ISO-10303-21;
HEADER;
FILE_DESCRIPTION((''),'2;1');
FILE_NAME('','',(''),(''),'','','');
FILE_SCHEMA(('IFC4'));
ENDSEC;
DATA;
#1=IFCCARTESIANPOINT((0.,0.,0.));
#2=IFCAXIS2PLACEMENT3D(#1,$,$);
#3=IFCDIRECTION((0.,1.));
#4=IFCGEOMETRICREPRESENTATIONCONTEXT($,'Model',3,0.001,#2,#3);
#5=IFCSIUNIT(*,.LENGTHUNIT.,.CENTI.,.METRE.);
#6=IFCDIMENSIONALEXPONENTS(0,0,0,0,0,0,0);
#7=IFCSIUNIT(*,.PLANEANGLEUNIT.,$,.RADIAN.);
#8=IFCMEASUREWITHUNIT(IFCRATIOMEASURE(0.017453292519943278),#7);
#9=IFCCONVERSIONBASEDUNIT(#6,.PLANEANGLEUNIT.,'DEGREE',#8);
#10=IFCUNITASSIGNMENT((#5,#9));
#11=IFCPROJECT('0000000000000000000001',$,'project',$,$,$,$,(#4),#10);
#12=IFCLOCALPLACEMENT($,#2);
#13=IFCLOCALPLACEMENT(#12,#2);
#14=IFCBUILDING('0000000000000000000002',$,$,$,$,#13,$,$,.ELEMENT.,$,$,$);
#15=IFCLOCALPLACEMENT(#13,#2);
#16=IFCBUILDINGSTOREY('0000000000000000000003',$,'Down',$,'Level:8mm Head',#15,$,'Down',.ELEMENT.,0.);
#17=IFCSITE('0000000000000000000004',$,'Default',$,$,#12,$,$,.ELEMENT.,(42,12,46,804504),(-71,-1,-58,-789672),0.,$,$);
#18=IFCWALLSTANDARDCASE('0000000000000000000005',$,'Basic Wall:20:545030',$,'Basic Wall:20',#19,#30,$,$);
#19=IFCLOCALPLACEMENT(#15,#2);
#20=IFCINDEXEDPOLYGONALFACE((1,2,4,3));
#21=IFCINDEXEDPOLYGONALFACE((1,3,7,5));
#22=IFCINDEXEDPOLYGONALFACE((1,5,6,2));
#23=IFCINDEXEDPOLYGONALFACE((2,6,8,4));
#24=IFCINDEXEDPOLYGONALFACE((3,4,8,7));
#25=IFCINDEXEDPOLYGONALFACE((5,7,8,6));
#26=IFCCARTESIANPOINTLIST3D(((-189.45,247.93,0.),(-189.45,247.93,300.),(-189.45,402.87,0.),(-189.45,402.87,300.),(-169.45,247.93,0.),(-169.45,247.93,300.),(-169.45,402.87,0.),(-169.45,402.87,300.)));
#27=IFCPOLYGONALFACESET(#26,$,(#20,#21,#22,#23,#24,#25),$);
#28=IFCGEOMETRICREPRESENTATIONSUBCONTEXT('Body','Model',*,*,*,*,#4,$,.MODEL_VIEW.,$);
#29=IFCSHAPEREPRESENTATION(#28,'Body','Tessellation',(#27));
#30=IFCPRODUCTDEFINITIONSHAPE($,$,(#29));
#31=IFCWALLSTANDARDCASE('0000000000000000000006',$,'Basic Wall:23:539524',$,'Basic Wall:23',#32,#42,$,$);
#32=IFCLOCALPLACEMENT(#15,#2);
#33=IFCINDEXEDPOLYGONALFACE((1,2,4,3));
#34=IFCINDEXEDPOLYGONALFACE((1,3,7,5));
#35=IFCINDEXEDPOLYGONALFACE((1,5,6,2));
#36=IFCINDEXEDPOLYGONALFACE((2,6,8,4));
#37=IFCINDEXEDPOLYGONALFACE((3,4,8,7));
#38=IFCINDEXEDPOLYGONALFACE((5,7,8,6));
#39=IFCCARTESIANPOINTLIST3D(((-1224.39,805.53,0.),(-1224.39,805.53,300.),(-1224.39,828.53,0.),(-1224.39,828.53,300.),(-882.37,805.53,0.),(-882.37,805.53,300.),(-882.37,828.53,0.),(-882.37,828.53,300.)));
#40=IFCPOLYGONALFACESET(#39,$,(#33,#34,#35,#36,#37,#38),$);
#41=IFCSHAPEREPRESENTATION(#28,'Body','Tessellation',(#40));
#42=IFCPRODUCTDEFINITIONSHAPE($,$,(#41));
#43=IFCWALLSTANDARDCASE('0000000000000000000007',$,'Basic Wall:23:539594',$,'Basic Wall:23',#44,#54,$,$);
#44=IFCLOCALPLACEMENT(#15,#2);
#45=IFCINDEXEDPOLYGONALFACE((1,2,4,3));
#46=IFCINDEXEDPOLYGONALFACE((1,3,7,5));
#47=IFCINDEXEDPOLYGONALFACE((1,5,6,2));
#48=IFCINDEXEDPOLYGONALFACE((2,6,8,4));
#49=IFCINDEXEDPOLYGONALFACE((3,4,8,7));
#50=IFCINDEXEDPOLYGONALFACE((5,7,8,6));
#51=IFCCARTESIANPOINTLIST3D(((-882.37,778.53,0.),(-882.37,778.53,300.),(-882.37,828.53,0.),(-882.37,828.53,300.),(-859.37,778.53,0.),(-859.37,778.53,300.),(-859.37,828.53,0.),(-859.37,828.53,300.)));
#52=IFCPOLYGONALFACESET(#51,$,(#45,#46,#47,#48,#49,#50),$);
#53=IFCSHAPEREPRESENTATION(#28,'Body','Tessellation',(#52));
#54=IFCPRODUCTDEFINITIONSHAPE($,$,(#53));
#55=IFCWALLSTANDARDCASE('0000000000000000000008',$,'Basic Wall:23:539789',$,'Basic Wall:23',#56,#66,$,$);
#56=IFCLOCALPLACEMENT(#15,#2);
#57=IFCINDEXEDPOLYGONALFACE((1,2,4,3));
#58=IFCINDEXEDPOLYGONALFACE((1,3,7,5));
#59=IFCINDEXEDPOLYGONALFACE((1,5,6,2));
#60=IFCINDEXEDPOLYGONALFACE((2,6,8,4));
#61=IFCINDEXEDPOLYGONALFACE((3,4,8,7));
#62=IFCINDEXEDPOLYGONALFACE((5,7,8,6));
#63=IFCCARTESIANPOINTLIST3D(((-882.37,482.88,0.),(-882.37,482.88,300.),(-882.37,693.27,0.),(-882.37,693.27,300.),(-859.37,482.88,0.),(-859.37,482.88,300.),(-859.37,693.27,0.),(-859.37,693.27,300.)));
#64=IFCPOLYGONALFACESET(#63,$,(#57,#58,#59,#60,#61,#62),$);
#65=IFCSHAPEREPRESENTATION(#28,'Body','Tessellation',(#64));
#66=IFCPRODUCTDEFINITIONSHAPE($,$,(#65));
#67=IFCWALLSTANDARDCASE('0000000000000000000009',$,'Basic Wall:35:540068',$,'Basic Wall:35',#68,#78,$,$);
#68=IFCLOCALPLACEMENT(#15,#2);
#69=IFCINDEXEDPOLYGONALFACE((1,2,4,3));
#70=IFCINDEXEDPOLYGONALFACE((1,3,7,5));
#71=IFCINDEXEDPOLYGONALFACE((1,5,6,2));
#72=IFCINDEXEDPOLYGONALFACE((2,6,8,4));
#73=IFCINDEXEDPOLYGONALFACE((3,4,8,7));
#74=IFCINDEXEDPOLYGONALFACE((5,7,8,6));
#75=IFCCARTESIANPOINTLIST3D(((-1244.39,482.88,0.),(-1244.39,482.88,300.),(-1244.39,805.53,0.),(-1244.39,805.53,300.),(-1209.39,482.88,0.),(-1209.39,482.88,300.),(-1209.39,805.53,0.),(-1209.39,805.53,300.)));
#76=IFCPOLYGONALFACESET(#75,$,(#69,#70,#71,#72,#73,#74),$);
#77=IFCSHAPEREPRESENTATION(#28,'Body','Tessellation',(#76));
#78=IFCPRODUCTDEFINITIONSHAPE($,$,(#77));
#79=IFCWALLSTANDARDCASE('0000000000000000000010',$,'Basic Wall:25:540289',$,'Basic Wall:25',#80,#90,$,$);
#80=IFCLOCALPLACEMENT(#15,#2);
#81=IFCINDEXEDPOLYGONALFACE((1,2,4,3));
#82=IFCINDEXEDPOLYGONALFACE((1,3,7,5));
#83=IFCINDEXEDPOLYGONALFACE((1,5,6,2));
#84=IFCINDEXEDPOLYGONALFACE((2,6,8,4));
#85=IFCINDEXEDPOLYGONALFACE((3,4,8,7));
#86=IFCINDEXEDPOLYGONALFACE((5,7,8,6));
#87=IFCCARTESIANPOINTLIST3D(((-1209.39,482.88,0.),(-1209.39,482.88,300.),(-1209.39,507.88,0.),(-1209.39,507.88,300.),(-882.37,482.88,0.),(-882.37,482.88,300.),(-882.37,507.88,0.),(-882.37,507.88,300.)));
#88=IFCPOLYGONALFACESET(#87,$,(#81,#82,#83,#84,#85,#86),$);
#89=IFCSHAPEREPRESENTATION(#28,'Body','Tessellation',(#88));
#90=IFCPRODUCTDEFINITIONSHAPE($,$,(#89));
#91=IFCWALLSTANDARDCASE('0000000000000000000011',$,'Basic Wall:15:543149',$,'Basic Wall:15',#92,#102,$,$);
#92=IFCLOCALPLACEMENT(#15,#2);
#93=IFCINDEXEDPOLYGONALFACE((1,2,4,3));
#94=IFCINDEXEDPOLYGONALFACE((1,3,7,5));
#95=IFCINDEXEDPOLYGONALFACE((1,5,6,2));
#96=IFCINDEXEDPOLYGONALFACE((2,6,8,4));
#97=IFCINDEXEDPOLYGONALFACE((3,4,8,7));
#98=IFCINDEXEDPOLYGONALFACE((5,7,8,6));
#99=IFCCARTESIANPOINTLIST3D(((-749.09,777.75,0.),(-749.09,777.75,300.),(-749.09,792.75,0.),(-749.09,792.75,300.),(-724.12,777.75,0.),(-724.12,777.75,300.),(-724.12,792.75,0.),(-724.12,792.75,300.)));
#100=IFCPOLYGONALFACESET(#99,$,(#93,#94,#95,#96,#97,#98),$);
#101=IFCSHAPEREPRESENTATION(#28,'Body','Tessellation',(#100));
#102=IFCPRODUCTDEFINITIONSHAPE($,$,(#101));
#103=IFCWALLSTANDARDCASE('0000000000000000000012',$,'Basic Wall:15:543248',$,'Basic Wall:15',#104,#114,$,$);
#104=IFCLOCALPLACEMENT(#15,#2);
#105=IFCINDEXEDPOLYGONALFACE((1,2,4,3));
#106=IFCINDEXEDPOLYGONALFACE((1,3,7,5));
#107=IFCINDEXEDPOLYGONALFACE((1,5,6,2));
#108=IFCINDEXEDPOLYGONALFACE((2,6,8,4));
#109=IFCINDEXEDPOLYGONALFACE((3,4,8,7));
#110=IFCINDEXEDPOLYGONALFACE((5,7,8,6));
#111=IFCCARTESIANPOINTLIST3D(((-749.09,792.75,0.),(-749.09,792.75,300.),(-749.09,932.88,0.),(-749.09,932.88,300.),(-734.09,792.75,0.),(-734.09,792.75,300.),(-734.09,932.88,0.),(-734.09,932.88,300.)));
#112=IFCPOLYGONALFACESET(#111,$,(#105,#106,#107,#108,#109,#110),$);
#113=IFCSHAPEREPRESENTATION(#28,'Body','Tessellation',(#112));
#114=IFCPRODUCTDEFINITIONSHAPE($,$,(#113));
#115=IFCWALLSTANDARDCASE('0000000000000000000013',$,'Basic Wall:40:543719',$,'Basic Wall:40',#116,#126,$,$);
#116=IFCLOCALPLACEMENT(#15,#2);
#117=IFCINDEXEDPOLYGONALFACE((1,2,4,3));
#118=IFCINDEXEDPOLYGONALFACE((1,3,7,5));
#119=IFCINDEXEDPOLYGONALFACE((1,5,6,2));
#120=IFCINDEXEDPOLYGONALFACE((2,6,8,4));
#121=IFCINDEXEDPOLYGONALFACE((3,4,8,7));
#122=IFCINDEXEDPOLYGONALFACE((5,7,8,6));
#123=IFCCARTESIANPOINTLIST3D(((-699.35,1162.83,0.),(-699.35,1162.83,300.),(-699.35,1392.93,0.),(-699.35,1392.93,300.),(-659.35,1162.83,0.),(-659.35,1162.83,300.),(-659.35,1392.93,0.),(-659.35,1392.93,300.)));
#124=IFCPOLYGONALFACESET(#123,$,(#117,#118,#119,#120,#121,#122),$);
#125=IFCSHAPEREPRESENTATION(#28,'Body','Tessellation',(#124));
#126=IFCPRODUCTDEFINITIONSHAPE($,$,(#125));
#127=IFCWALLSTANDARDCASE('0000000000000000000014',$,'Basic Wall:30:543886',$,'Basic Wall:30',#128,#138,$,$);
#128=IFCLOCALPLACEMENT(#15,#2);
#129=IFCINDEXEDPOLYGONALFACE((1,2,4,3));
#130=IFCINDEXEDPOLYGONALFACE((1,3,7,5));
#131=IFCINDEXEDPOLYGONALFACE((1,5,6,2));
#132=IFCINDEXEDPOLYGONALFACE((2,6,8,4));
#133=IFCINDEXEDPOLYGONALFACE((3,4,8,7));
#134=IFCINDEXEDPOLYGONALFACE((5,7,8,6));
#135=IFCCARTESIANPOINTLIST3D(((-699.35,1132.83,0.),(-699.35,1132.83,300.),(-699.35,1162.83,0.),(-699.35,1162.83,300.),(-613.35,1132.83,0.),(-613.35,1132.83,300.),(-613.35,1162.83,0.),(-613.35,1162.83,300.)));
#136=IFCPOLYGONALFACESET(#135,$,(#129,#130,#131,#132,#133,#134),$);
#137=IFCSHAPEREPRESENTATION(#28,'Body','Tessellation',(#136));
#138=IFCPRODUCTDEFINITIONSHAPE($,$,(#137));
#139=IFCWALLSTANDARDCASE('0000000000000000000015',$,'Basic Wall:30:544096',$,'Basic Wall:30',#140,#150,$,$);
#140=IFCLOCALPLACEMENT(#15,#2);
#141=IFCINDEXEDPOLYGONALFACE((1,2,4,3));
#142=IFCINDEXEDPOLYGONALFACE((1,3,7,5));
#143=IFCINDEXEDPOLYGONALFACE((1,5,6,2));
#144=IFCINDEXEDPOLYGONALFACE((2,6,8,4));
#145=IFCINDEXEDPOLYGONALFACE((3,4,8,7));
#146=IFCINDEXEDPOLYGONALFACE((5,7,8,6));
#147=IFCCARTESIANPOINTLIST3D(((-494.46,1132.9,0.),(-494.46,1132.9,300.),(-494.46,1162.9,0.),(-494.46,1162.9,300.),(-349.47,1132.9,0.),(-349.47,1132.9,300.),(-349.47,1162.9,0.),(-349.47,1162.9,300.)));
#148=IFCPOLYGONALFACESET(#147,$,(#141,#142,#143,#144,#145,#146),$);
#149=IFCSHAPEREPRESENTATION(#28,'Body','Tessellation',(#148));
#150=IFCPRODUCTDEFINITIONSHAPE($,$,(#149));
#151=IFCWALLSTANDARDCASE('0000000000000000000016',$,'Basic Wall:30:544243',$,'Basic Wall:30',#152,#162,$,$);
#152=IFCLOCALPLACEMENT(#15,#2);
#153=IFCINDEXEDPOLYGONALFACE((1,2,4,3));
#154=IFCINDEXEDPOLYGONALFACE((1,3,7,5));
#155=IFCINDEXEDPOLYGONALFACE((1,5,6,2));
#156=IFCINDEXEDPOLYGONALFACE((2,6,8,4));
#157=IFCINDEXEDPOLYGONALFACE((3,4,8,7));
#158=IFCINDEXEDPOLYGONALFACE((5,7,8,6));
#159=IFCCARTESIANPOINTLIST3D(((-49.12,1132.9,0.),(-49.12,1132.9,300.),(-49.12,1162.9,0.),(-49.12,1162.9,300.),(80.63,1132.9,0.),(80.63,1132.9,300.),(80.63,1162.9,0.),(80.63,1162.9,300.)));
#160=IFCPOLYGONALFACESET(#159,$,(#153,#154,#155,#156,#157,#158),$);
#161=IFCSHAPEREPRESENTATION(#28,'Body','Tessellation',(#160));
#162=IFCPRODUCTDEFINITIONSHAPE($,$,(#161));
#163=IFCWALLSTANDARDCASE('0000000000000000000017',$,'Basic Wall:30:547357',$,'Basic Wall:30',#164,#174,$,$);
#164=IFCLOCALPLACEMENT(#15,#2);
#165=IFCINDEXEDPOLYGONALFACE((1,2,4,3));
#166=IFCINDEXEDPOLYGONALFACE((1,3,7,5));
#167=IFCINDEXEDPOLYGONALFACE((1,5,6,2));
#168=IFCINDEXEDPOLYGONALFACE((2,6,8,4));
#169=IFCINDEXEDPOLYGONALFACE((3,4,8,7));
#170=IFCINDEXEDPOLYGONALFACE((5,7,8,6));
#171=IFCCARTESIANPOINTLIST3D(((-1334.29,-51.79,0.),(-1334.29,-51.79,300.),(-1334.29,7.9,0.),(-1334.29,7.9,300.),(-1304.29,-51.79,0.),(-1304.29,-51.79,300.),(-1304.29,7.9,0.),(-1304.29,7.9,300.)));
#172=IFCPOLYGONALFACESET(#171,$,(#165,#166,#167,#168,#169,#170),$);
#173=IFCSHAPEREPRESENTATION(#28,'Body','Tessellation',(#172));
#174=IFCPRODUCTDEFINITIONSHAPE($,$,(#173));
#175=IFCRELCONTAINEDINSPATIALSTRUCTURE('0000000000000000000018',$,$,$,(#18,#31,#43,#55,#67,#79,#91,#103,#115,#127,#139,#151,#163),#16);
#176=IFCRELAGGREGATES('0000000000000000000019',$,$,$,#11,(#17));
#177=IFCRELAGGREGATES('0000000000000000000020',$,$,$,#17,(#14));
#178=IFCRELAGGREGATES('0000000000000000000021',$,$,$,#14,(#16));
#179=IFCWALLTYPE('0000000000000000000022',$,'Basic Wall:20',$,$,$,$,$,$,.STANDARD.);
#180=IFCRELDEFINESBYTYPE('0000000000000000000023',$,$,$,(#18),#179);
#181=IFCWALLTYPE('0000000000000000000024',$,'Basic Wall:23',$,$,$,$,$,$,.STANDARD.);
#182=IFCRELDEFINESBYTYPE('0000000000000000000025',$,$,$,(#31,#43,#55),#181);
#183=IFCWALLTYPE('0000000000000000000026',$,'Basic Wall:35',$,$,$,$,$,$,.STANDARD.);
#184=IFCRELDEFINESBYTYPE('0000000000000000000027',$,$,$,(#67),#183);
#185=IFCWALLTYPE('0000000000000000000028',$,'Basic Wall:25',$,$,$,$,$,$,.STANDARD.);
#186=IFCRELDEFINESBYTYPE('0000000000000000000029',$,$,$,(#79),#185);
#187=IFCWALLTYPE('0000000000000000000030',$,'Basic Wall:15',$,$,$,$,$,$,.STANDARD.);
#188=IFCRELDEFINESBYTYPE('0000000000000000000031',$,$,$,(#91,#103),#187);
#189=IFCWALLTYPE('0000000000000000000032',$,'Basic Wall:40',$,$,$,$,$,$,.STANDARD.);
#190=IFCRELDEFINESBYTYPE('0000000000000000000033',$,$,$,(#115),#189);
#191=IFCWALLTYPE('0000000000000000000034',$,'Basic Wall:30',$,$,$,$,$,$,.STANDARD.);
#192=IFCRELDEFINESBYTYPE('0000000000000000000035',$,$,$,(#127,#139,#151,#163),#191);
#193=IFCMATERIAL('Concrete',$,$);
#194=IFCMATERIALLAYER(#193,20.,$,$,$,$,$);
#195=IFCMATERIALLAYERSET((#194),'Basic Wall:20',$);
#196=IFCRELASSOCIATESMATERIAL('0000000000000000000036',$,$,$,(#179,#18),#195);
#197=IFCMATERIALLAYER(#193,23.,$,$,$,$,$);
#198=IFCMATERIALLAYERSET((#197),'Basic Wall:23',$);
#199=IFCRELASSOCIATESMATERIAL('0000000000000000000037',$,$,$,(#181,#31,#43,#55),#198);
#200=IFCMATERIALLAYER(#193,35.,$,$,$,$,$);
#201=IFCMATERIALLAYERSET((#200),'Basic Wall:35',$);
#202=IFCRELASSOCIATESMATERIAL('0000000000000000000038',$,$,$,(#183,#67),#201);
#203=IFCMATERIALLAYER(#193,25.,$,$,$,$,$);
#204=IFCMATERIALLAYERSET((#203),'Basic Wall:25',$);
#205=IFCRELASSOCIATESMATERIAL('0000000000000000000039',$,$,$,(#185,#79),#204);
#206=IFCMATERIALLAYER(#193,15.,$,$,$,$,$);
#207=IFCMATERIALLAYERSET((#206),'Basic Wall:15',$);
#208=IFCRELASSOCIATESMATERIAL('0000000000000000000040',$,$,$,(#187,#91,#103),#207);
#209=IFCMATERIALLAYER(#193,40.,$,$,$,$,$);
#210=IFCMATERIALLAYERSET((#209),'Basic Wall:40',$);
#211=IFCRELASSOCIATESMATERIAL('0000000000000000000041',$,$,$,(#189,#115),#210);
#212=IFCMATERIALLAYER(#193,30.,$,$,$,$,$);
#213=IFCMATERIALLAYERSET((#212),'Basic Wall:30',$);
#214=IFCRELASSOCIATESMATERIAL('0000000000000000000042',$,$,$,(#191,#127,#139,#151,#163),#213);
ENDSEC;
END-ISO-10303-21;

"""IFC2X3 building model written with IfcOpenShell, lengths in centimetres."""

from ifc_helpers import new_model, entity, si_unit, converted_unit, direction, frame, frame_2d, origin, place, context, subcontext, project, spatial, rectangle, extrude, material, layer, layer_set, layer_usage, type_object, element, save


model = new_model("IFC2X3")

# Units and contexts
model_context = context("Model", 3, precision=0.001, world=origin(), true_north=direction((0.0, 1.0)))
body_context = subcontext(model_context, "Body", "Model", "MODEL_VIEW")
ifc_project = project(units=[si_unit("LENGTHUNIT", "METRE", prefix="CENTI"), converted_unit("PLANEANGLEUNIT", "DEGREE", entity("IfcRatioMeasure", 0.017453292519943278), si_unit("PLANEANGLEUNIT", "RADIAN"), dimensions=[0, 0, 0, 0, 0, 0, 0])], contexts=[model_context])

# Site, building, storey
site_placement = place(None, origin())
site = spatial("IfcSite", under=ifc_project, at=site_placement, Name="Default", CompositionType="ELEMENT", RefLatitude=(42, 12, 46, 804504), RefLongitude=(-71, -1, -58, -789672), RefElevation=0.0)
building_placement = place(site_placement, origin())
building = spatial("IfcBuilding", under=site, at=building_placement, CompositionType="ELEMENT")
storey_placement = place(building_placement, origin())
storey = spatial("IfcBuildingStorey", under=building, at=storey_placement, Name="Down", ObjectType="Level:8mm Head", LongName="Down", CompositionType="ELEMENT", Elevation=0.0)

# Walls
ifc_material = material(Name="Concrete")
ifc_layer_1 = layer(ifc_material, 20.0)
ifc_layer_set_1 = layer_set([ifc_layer_1], Name="Basic Wall:20")
wall_type_1 = type_object("IfcWallType", Name="Basic Wall:20", PredefinedType="STANDARD", material=ifc_layer_set_1)
ifc_layer_usage_1 = layer_usage(ifc_layer_set_1, "AXIS2", "POSITIVE", -10.0)
wall_1_placement = place(storey_placement, frame((-179.45, 402.87, 0.0), z_axis=(0.0, 0.0, 1.0), x_axis=(0.0, -1.0, 0.0)))
element("IfcWallStandardCase", 1, at=wall_1_placement, inside=storey, type_object=wall_type_1, material=ifc_layer_usage_1, Name="Basic Wall:20:545030", ObjectType="Basic Wall:20", context=body_context, shape_type="SweptSolid", body=[
    extrude(rectangle(XDim=154.94, YDim=20.0, at=frame_2d((77.47, 0.0), x_axis=(-1.0, 0.0))), origin(), (0.0, 0.0, 1.0), 300.0),
])
ifc_layer_2 = layer(ifc_material, 23.0)
ifc_layer_set_2 = layer_set([ifc_layer_2], Name="Basic Wall:23")
ifc_layer_usage_2 = layer_usage(ifc_layer_set_2, "AXIS2", "NEGATIVE", 11.5)
wall_type_2 = type_object("IfcWallType", Name="Basic Wall:23", PredefinedType="STANDARD", material=ifc_layer_set_2)
wall_2_placement = place(storey_placement, frame((-1224.39, 817.03, 0.0)))
element("IfcWallStandardCase", 2, at=wall_2_placement, inside=storey, type_object=wall_type_2, material=ifc_layer_usage_2, Name="Basic Wall:23:539524", ObjectType="Basic Wall:23", context=body_context, shape_type="SweptSolid", body=[
    extrude(rectangle(XDim=342.02, YDim=23.0, at=frame_2d((171.01, 0.0), x_axis=(-1.0, 0.0))), origin(), (0.0, 0.0, 1.0), 300.0),
])
ifc_layer_usage_3 = layer_usage(ifc_layer_set_2, "AXIS2", "NEGATIVE", 11.5)
wall_3_placement = place(storey_placement, frame((-870.87, 828.53, 0.0), z_axis=(0.0, 0.0, 1.0), x_axis=(0.0, -1.0, 0.0)))
element("IfcWallStandardCase", 3, at=wall_3_placement, inside=storey, type_object=wall_type_2, material=ifc_layer_usage_3, Name="Basic Wall:23:539594", ObjectType="Basic Wall:23", context=body_context, shape_type="SweptSolid", body=[
    extrude(rectangle(XDim=50.0, YDim=23.0, at=frame_2d((25.0, 0.0), x_axis=(-1.0, 0.0))), origin(), (0.0, 0.0, 1.0), 300.0),
])
ifc_layer_usage_4 = layer_usage(ifc_layer_set_2, "AXIS2", "NEGATIVE", 11.5)
wall_4_placement = place(storey_placement, frame((-870.87, 693.27, 0.0), z_axis=(0.0, 0.0, 1.0), x_axis=(0.0, -1.0, 0.0)))
element("IfcWallStandardCase", 4, at=wall_4_placement, inside=storey, type_object=wall_type_2, material=ifc_layer_usage_4, Name="Basic Wall:23:539789", ObjectType="Basic Wall:23", context=body_context, shape_type="SweptSolid", body=[
    extrude(rectangle(XDim=210.4, YDim=23.0, at=frame_2d((105.2, 0.0), x_axis=(-1.0, 0.0))), origin(), (0.0, 0.0, 1.0), 300.0),
])
ifc_layer_3 = layer(ifc_material, 35.0)
ifc_layer_set_3 = layer_set([ifc_layer_3], Name="Basic Wall:35")
ifc_layer_usage_5 = layer_usage(ifc_layer_set_3, "AXIS2", "POSITIVE", -17.5)
wall_type_3 = type_object("IfcWallType", Name="Basic Wall:35", PredefinedType="STANDARD", material=ifc_layer_set_3)
wall_5_placement = place(storey_placement, frame((-1226.89, 805.53, 0.0), z_axis=(0.0, 0.0, 1.0), x_axis=(0.0, -1.0, 0.0)))
element("IfcWallStandardCase", 5, at=wall_5_placement, inside=storey, type_object=wall_type_3, material=ifc_layer_usage_5, Name="Basic Wall:35:540068", ObjectType="Basic Wall:35", context=body_context, shape_type="SweptSolid", body=[
    extrude(rectangle(XDim=322.65, YDim=35.0, at=frame_2d((161.32, 0.0), x_axis=(-1.0, 0.0))), origin(), (0.0, 0.0, 1.0), 300.0),
])
ifc_layer_4 = layer(ifc_material, 25.0)
ifc_layer_set_4 = layer_set([ifc_layer_4], Name="Basic Wall:25")
ifc_layer_usage_6 = layer_usage(ifc_layer_set_4, "AXIS2", "POSITIVE", -12.5)
wall_type_4 = type_object("IfcWallType", Name="Basic Wall:25", PredefinedType="STANDARD", material=ifc_layer_set_4)
wall_6_placement = place(storey_placement, frame((-1209.39, 495.38, 0.0)))
element("IfcWallStandardCase", 6, at=wall_6_placement, inside=storey, type_object=wall_type_4, material=ifc_layer_usage_6, Name="Basic Wall:25:540289", ObjectType="Basic Wall:25", context=body_context, shape_type="SweptSolid", body=[
    extrude(rectangle(XDim=327.02, YDim=25.0, at=frame_2d((163.51, 0.0), x_axis=(-1.0, 0.0))), origin(), (0.0, 0.0, 1.0), 300.0),
])
ifc_layer_5 = layer(ifc_material, 15.0)
ifc_layer_set_5 = layer_set([ifc_layer_5], Name="Basic Wall:15")
ifc_layer_usage_7 = layer_usage(ifc_layer_set_5, "AXIS2", "POSITIVE", -7.5)
wall_type_5 = type_object("IfcWallType", Name="Basic Wall:15", PredefinedType="STANDARD", material=ifc_layer_set_5)
wall_7_placement = place(storey_placement, frame((-724.12, 785.25, 0.0), z_axis=(0.0, 0.0, 1.0), x_axis=(-1.0, 0.0, 0.0)))
element("IfcWallStandardCase", 7, at=wall_7_placement, inside=storey, type_object=wall_type_5, material=ifc_layer_usage_7, Name="Basic Wall:15:543149", ObjectType="Basic Wall:15", context=body_context, shape_type="SweptSolid", body=[
    extrude(rectangle(XDim=24.98, YDim=15.0, at=frame_2d((12.49, 0.0), x_axis=(-1.0, 0.0))), origin(), (0.0, 0.0, 1.0), 300.0),
])
ifc_layer_usage_8 = layer_usage(ifc_layer_set_5, "AXIS2", "NEGATIVE", 7.5)
wall_8_placement = place(storey_placement, frame((-741.59, 792.75, 0.0), z_axis=(0.0, 0.0, 1.0), x_axis=(0.0, 1.0, 0.0)))
element("IfcWallStandardCase", 8, at=wall_8_placement, inside=storey, type_object=wall_type_5, material=ifc_layer_usage_8, Name="Basic Wall:15:543248", ObjectType="Basic Wall:15", context=body_context, shape_type="SweptSolid", body=[
    extrude(rectangle(XDim=140.12, YDim=15.0, at=frame_2d((70.06, 0.0), x_axis=(-1.0, 0.0))), origin(), (0.0, 0.0, 1.0), 300.0),
])
ifc_layer_6 = layer(ifc_material, 40.0)
ifc_layer_set_6 = layer_set([ifc_layer_6], Name="Basic Wall:40")
ifc_layer_usage_9 = layer_usage(ifc_layer_set_6, "AXIS2", "NEGATIVE", 20.0)
wall_type_6 = type_object("IfcWallType", Name="Basic Wall:40", PredefinedType="STANDARD", material=ifc_layer_set_6)
wall_9_placement = place(storey_placement, frame((-679.35, 1392.93, 0.0), z_axis=(0.0, 0.0, 1.0), x_axis=(0.0, -1.0, 0.0)))
element("IfcWallStandardCase", 9, at=wall_9_placement, inside=storey, type_object=wall_type_6, material=ifc_layer_usage_9, Name="Basic Wall:40:543719", ObjectType="Basic Wall:40", context=body_context, shape_type="SweptSolid", body=[
    extrude(rectangle(XDim=230.11, YDim=40.0, at=frame_2d((115.05, 0.0), x_axis=(-1.0, 0.0))), origin(), (0.0, 0.0, 1.0), 300.0),
])
ifc_layer_7 = layer(ifc_material, 30.0)
ifc_layer_set_7 = layer_set([ifc_layer_7], Name="Basic Wall:30")
ifc_layer_usage_10 = layer_usage(ifc_layer_set_7, "AXIS2", "POSITIVE", -15.0)
wall_type_7 = type_object("IfcWallType", Name="Basic Wall:30", PredefinedType="STANDARD", material=ifc_layer_set_7)
wall_10_placement = place(storey_placement, frame((-699.35, 1147.83, 0.0)))
element("IfcWallStandardCase", 10, at=wall_10_placement, inside=storey, type_object=wall_type_7, material=ifc_layer_usage_10, Name="Basic Wall:30:543886", ObjectType="Basic Wall:30", context=body_context, shape_type="SweptSolid", body=[
    extrude(rectangle(XDim=86.0, YDim=30.0, at=frame_2d((43.0, 0.0), x_axis=(-1.0, 0.0))), origin(), (0.0, 0.0, 1.0), 300.0),
])
ifc_layer_usage_11 = layer_usage(ifc_layer_set_7, "AXIS2", "POSITIVE", -15.0)
wall_11_placement = place(storey_placement, frame((-494.46, 1147.9, 0.0)))
element("IfcWallStandardCase", 11, at=wall_11_placement, inside=storey, type_object=wall_type_7, material=ifc_layer_usage_11, Name="Basic Wall:30:544096", ObjectType="Basic Wall:30", context=body_context, shape_type="SweptSolid", body=[
    extrude(rectangle(XDim=144.99, YDim=30.0, at=frame_2d((72.5, 0.0), x_axis=(-1.0, 0.0))), origin(), (0.0, 0.0, 1.0), 300.0),
])
ifc_layer_usage_12 = layer_usage(ifc_layer_set_7, "AXIS2", "POSITIVE", -15.0)
wall_12_placement = place(storey_placement, frame((-49.12, 1147.9, 0.0)))
element("IfcWallStandardCase", 12, at=wall_12_placement, inside=storey, type_object=wall_type_7, material=ifc_layer_usage_12, Name="Basic Wall:30:544243", ObjectType="Basic Wall:30", context=body_context, shape_type="SweptSolid", body=[
    extrude(rectangle(XDim=129.75, YDim=30.0, at=frame_2d((64.88, 0.0), x_axis=(-1.0, 0.0))), origin(), (0.0, 0.0, 1.0), 300.0),
])
ifc_layer_usage_13 = layer_usage(ifc_layer_set_7, "AXIS2", "POSITIVE", -15.0)
wall_13_placement = place(storey_placement, frame((-1319.29, -51.79, 0.0), z_axis=(0.0, 0.0, 1.0), x_axis=(0.0, 1.0, 0.0)))
element("IfcWallStandardCase", 13, at=wall_13_placement, inside=storey, type_object=wall_type_7, material=ifc_layer_usage_13, Name="Basic Wall:30:547357", ObjectType="Basic Wall:30", context=body_context, shape_type="SweptSolid", body=[
    extrude(rectangle(XDim=59.69, YDim=30.0, at=frame_2d((29.84, 0.0), x_axis=(-1.0, 0.0))), origin(), (0.0, 0.0, 1.0), 300.0),
])

save(model, "model.ifc")
